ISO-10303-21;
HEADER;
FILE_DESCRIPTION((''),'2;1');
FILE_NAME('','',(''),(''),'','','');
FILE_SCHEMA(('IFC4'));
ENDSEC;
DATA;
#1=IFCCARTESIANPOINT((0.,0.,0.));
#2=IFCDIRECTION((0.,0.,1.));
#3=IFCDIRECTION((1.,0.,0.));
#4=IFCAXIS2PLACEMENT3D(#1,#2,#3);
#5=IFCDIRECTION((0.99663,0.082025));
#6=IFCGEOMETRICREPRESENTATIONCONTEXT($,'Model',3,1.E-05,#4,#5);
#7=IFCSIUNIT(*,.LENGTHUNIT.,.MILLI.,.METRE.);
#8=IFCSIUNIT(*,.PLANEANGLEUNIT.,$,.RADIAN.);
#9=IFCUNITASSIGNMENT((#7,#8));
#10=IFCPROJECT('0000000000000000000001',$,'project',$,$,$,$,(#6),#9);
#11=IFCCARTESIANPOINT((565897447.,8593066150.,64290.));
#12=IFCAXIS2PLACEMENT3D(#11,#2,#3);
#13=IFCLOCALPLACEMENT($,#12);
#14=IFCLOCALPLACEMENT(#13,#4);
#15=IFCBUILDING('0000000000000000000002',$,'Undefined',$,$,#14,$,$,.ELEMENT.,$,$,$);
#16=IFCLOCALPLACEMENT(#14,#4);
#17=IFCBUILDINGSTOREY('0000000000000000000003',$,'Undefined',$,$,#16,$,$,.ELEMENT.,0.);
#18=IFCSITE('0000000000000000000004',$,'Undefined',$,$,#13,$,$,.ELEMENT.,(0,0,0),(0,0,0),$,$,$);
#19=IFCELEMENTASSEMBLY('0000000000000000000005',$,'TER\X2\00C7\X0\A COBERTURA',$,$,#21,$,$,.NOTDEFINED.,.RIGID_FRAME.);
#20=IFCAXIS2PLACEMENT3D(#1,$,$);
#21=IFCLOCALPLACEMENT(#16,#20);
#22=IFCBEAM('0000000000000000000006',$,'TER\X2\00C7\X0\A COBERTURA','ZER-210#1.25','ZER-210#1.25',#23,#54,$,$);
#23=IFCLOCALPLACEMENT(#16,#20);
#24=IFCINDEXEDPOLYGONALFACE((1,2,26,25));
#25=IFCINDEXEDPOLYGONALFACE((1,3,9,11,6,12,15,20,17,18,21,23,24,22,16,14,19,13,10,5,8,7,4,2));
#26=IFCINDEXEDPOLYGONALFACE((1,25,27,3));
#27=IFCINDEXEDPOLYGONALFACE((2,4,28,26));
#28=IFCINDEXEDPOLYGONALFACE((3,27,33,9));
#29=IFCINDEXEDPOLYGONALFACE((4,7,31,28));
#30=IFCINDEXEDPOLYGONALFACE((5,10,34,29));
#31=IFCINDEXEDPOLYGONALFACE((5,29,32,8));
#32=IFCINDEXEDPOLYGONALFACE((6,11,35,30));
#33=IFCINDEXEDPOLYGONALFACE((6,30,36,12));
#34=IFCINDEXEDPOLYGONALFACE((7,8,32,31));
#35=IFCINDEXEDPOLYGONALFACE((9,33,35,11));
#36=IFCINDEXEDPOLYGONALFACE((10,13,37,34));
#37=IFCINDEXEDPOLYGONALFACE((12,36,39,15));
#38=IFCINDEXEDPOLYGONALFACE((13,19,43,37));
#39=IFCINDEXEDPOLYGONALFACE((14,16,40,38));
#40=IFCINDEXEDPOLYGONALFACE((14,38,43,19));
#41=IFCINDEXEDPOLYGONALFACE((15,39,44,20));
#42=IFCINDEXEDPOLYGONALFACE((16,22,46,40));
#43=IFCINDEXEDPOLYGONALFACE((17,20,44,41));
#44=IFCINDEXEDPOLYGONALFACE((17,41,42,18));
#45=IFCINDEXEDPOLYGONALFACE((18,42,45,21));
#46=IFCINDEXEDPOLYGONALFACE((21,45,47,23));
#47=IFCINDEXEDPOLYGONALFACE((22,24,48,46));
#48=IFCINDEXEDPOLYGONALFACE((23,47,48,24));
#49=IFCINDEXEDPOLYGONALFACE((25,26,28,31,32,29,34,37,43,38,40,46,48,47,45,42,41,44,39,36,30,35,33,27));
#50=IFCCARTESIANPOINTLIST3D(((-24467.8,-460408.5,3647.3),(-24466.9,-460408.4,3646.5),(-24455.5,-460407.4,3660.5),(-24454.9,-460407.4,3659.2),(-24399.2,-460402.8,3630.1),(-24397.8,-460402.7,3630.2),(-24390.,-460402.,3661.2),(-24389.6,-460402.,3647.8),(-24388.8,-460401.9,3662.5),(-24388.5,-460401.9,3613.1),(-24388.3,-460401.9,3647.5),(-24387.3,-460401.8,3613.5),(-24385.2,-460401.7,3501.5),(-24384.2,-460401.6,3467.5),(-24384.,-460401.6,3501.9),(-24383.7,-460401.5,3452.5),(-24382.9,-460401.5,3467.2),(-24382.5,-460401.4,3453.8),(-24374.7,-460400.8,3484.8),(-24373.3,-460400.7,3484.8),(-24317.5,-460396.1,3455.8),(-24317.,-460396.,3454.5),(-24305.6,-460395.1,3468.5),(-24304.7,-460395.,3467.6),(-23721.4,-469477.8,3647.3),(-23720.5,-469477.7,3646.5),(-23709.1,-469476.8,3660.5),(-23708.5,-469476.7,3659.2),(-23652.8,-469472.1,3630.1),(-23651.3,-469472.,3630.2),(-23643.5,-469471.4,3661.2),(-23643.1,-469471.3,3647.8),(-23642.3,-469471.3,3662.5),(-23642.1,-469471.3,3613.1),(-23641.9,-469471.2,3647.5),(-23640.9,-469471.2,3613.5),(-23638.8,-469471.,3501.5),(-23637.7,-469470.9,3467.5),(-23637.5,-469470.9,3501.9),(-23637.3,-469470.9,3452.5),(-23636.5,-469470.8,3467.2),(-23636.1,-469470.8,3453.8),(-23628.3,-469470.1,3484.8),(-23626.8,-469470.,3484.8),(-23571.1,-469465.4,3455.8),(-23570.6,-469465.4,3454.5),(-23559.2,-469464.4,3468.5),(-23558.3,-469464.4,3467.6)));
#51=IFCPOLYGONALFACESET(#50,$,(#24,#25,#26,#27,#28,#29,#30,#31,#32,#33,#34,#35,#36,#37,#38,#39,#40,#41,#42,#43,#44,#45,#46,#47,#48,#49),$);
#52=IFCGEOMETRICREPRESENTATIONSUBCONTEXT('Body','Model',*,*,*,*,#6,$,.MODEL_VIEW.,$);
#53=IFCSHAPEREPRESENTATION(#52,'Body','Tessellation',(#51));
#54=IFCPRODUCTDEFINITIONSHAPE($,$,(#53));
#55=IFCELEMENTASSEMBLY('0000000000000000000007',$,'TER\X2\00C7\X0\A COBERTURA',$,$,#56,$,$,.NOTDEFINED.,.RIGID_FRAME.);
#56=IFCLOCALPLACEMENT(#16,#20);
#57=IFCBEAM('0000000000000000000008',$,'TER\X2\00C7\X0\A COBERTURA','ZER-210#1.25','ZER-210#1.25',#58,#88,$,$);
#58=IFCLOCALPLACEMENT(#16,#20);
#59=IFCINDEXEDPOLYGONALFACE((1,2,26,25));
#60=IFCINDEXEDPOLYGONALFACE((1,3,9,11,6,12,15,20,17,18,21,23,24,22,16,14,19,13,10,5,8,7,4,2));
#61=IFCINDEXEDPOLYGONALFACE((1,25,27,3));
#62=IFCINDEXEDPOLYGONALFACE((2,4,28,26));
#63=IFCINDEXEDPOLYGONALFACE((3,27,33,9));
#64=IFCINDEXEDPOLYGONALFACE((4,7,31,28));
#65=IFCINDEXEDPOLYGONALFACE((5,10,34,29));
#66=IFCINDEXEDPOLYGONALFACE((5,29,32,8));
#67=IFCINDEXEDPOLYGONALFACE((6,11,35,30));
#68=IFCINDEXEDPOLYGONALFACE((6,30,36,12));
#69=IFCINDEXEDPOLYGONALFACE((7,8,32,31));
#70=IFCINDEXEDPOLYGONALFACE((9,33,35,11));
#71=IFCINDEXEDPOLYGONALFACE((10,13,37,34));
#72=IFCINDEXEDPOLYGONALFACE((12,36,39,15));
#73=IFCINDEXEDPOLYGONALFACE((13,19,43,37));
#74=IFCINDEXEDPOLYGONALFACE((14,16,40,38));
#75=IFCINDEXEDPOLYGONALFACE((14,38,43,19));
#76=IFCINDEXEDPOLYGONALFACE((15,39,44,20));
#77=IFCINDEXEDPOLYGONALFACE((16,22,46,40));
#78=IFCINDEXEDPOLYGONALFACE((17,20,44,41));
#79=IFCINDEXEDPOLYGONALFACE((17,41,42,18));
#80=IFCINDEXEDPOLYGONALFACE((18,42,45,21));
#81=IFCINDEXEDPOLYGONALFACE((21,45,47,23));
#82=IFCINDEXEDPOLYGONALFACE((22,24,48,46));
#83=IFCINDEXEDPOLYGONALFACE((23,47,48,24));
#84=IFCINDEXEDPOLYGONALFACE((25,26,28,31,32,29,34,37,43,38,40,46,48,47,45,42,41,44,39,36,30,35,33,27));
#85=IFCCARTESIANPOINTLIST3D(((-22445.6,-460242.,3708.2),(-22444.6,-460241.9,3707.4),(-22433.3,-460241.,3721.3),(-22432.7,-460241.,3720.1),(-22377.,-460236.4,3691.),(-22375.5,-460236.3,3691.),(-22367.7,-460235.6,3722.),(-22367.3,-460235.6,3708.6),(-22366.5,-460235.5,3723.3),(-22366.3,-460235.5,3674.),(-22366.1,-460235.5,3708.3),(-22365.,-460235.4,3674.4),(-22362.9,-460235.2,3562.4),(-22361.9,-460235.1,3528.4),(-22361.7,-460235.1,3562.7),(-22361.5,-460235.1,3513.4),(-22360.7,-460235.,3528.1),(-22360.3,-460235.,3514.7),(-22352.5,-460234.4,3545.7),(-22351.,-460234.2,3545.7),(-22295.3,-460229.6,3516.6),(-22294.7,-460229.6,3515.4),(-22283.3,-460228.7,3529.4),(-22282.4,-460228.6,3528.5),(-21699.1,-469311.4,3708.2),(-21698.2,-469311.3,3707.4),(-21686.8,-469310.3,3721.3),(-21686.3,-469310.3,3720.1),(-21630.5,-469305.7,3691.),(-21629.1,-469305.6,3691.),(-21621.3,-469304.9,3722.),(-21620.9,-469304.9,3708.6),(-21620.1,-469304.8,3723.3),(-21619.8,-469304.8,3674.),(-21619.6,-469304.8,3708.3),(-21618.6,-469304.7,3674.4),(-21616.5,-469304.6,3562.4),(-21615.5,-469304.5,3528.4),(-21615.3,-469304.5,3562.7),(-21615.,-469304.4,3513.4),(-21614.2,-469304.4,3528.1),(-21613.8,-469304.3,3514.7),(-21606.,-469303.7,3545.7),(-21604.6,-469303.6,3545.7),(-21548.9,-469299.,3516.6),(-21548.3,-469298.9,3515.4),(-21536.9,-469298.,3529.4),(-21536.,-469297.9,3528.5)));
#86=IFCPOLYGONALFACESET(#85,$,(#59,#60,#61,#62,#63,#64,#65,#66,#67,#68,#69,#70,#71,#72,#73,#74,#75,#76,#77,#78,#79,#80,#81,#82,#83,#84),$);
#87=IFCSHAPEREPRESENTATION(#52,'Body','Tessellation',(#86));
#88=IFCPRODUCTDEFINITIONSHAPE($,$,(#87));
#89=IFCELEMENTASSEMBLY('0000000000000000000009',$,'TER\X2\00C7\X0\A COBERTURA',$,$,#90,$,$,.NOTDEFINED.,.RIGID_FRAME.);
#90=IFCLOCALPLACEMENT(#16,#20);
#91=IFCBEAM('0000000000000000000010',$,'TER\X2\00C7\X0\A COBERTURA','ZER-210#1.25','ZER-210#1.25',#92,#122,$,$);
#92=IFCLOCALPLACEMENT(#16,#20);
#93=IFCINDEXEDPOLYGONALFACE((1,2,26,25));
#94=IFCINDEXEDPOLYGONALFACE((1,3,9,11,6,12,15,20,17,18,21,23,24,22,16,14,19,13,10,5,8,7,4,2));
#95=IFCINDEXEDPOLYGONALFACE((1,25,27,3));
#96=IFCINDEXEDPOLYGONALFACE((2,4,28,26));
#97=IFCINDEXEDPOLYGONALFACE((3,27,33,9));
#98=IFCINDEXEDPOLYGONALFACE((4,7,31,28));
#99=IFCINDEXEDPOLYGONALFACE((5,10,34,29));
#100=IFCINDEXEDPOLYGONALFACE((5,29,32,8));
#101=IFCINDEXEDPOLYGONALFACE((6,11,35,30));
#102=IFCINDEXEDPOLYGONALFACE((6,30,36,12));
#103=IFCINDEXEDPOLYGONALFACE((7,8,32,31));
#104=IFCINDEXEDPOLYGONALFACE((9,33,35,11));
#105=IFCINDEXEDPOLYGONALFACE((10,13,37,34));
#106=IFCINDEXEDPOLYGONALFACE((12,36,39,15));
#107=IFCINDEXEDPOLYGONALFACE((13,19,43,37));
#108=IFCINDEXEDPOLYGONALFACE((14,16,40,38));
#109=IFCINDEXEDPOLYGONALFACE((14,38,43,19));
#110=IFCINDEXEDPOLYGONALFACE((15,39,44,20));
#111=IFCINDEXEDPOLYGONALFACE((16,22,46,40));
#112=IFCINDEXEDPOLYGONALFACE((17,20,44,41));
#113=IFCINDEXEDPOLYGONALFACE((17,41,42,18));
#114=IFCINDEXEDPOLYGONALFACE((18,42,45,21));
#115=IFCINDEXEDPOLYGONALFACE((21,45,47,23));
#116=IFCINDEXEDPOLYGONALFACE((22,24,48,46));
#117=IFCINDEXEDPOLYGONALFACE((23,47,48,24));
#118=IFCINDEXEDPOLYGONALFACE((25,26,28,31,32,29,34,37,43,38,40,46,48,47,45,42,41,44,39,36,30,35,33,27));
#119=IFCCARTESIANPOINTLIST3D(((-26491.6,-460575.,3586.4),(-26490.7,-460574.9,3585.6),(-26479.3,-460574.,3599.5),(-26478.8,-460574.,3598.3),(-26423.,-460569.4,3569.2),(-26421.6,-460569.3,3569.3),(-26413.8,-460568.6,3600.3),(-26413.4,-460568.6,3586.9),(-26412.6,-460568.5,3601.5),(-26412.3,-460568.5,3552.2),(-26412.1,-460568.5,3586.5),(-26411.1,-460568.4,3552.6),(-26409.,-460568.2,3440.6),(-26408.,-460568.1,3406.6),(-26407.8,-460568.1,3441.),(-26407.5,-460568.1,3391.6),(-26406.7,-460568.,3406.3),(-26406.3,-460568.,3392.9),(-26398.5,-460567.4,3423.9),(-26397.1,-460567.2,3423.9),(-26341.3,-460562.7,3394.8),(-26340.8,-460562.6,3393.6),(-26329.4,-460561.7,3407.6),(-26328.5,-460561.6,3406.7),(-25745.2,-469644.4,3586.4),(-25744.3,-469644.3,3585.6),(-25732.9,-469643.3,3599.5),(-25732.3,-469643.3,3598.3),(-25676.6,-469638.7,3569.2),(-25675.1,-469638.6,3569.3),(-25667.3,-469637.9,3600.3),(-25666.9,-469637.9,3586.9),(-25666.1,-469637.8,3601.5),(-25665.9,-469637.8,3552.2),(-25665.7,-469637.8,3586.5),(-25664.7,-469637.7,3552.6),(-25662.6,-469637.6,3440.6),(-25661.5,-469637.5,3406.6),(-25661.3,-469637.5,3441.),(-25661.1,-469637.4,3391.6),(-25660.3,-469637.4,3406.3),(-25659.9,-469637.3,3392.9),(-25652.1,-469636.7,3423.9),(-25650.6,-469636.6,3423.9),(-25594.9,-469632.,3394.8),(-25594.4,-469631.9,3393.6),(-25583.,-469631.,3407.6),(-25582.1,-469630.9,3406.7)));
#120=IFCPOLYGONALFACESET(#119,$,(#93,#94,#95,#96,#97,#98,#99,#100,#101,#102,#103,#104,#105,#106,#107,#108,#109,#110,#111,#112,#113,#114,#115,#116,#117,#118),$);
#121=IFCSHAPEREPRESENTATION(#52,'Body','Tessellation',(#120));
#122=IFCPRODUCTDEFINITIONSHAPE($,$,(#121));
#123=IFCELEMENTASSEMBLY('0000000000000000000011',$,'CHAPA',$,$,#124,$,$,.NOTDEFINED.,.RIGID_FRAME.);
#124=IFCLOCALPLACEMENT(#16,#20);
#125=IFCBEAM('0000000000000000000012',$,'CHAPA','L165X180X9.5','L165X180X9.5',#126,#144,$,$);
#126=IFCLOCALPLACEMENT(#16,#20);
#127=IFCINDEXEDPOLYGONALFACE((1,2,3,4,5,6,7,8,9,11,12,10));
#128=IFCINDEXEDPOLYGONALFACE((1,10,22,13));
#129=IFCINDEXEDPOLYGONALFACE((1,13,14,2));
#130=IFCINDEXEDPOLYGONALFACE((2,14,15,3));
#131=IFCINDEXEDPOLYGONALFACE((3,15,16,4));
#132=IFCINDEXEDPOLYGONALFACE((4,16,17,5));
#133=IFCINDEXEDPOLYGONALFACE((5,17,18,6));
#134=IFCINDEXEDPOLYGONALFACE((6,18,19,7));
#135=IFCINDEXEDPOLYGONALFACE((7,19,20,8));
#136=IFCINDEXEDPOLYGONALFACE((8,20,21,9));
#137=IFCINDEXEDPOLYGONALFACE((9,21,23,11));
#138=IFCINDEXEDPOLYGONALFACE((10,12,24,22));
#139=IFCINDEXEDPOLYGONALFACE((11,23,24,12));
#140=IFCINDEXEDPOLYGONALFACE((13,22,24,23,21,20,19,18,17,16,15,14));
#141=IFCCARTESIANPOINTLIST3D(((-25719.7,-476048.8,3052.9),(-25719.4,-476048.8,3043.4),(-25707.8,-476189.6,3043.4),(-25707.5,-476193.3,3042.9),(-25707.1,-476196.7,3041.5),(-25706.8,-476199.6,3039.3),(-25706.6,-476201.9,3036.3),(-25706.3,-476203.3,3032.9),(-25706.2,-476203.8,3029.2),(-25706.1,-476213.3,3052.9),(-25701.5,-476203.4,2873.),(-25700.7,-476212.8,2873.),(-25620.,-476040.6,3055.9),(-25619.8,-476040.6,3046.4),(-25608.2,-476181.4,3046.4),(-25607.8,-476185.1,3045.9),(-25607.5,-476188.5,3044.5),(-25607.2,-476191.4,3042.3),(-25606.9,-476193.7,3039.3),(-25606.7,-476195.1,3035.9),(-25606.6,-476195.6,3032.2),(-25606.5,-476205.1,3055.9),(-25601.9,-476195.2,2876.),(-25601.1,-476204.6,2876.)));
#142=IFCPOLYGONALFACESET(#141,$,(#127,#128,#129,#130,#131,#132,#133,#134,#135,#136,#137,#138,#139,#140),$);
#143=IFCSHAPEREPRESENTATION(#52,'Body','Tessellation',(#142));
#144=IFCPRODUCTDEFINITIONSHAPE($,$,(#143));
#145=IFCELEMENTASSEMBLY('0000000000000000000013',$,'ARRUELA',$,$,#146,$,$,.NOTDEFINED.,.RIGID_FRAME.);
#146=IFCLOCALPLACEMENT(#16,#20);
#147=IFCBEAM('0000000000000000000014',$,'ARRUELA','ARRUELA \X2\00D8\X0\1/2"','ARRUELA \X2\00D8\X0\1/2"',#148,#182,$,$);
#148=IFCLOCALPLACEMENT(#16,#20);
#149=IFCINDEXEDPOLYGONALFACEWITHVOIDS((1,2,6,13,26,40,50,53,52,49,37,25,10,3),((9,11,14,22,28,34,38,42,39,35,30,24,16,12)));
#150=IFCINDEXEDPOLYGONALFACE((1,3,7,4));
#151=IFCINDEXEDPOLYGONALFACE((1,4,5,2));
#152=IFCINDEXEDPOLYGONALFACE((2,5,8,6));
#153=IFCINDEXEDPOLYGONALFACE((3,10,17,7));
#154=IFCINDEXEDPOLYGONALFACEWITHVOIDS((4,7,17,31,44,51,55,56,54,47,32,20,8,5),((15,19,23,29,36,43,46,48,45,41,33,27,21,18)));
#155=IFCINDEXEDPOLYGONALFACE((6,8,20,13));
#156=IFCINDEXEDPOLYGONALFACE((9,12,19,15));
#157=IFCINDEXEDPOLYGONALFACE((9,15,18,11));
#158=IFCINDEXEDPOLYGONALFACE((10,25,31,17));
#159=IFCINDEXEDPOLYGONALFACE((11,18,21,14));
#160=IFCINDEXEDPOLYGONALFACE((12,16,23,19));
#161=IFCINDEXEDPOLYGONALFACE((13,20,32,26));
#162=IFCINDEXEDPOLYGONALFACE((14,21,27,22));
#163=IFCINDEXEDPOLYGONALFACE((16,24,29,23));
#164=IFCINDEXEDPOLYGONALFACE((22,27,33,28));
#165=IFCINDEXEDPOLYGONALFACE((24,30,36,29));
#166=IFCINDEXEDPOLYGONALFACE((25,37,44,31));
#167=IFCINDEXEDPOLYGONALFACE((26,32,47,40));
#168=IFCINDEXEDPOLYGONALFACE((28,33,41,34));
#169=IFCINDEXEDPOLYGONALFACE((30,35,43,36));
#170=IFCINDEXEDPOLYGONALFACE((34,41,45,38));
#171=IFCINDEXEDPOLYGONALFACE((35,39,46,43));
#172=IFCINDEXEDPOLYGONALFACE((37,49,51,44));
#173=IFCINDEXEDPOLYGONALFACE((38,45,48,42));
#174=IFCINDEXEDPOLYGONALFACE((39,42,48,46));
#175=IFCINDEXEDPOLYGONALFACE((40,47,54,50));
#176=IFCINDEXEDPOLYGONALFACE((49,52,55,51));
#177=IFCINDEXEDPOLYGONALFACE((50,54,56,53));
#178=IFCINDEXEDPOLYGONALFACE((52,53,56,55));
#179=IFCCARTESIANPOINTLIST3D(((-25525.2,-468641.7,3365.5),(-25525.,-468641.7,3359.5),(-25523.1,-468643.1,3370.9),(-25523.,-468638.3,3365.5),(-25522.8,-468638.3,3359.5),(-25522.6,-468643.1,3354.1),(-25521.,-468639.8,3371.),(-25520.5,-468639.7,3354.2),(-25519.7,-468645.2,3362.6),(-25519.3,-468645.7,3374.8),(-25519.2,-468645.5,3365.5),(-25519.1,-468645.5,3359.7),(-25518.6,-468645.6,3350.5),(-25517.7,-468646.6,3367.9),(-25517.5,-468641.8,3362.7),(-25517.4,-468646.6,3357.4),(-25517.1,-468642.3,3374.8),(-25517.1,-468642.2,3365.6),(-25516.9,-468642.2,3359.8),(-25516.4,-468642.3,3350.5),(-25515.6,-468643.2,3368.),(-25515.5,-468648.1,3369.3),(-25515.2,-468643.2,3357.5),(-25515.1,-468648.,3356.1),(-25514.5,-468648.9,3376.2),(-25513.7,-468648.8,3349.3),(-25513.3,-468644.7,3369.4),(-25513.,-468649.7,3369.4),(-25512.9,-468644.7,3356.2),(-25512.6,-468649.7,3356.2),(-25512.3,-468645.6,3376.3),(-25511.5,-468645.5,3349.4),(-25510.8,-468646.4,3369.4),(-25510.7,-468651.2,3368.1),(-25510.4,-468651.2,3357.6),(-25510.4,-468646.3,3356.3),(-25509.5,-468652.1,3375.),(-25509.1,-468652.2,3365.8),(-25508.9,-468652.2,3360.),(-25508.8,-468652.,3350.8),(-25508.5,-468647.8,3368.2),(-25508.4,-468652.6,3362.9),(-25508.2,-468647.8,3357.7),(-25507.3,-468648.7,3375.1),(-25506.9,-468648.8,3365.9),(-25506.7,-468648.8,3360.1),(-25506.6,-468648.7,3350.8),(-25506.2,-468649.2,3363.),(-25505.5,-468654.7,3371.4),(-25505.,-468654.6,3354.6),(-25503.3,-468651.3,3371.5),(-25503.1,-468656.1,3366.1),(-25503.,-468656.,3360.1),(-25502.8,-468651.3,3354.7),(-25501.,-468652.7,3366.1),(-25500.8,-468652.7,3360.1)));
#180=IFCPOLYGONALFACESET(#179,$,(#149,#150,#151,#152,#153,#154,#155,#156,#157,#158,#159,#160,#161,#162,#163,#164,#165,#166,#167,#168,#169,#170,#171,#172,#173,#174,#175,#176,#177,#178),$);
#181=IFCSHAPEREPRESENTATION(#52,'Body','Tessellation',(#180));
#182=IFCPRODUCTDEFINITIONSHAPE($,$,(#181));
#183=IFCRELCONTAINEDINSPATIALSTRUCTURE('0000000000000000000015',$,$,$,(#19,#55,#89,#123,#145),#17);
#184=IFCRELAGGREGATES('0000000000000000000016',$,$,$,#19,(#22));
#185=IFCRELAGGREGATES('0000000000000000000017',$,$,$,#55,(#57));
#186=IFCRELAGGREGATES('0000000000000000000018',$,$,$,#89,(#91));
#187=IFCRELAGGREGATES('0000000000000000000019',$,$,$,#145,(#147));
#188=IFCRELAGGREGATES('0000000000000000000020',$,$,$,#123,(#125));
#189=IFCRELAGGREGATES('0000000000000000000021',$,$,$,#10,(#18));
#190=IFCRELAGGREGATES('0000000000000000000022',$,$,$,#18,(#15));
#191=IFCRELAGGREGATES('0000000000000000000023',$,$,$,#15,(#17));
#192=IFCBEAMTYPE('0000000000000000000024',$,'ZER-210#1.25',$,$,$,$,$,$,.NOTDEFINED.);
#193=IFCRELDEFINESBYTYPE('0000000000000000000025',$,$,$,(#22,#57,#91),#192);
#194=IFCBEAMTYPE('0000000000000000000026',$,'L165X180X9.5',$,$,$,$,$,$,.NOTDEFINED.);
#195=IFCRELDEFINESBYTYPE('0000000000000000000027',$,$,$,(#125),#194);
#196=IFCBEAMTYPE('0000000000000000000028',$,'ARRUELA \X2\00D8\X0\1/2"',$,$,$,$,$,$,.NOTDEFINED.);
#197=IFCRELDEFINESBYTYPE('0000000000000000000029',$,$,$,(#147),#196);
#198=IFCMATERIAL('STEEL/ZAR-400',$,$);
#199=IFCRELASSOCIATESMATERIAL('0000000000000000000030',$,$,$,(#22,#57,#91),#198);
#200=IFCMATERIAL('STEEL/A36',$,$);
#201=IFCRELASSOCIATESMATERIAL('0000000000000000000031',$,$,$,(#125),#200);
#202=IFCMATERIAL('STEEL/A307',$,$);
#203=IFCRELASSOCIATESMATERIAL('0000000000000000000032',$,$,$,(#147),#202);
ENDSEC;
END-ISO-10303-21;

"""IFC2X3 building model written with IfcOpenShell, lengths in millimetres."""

from ifc_helpers import new_model, si_unit, direction, frame, origin_with_axes, origin_2d_with_axis, place, context, subcontext, project, spatial, polyline, l_section, outline, extrude, material, type_object, element, aggregate, save


model = new_model("IFC2X3")

# Units and contexts
model_context = context("Model", 3, precision=1e-05, world=origin_with_axes(), true_north=direction((0.99663, 0.082025)))
body_context = subcontext(model_context, "Body", "Model", "MODEL_VIEW")
ifc_project = project(units=[si_unit("LENGTHUNIT", "METRE", prefix="MILLI"), si_unit("PLANEANGLEUNIT", "RADIAN")], contexts=[model_context])

# Site, building, storey
site_placement = place(None, frame((565897447.0, 8593066150.0, 64290.0), z_axis=(0.0, 0.0, 1.0), x_axis=(1.0, 0.0, 0.0)))
site = spatial("IfcSite", under=ifc_project, at=site_placement, Name="Undefined", CompositionType="ELEMENT", RefLatitude=(0, 0, 0), RefLongitude=(0, 0, 0))
building_placement = place(site_placement, origin_with_axes())
building = spatial("IfcBuilding", under=site, at=building_placement, Name="Undefined", CompositionType="ELEMENT")
storey_placement = place(building_placement, origin_with_axes())
storey = spatial("IfcBuildingStorey", under=building, at=storey_placement, Name="Undefined", CompositionType="ELEMENT", Elevation=0.0)

# Element assemblies, beams
assembly_1_placement = place(storey_placement, origin_with_axes())
assembly_1 = element("IfcElementAssembly", 1, at=assembly_1_placement, inside=storey, Name="TERÇA COBERTURA", AssemblyPlace="NOTDEFINED", PredefinedType="RIGID_FRAME")
ifc_material_1 = material(Name="STEEL/ZAR-400")
beam_type_1 = type_object("IfcBeamType", Name="ZER-210#1.25", PredefinedType="NOTDEFINED")
beam_1_placement = place(assembly_1_placement, frame((-23639.8, -469471.1, 3557.5), z_axis=(-0.029885, -0.00246, 0.99955), x_axis=(-0.082025, 0.99663, 0.0)))
beam_1 = element("IfcBeam", 2, at=beam_1_placement, type_object=beam_type_1, material=ifc_material_1, Name="TERÇA COBERTURA", Description="ZER-210#1.25", ObjectType="ZER-210#1.25", context=body_context, shape_type="SweptSolid", body=[
    extrude(outline(polyline([(-65.9, 103.7), (-78.2, 91.4), (-79.1, 92.3), (-66.4, 105.0), (0.6, 105.0), (0.6, 90.0), (-9.4, 73.0), (0.6, 56.0), (0.6, -55.7), (10.8, -73.0), (0.6, -90.3), (0.6, -103.8), (65.9, -103.7), (78.2, -91.4), (79.1, -92.3), (66.4, -105.0), (-0.6, -105.0), (-0.6, -90.0), (9.4, -73.0), (-0.6, -56.0), (-0.6, 55.7), (-10.8, 73.0), (-0.6, 90.3), (-0.6, 103.8), (-65.9, 103.7)])), frame((9100.0, 0.0, 0.0), z_axis=(-1.0, 0.0, 0.0), x_axis=(0.0, -1.0, 0.0)), (0.0, 0.0, 1.0), 9100.0),
])
aggregate(assembly_1, [beam_1])
assembly_2_placement = place(storey_placement, origin_with_axes())
assembly_2 = element("IfcElementAssembly", 3, at=assembly_2_placement, inside=storey, Name="TERÇA COBERTURA", AssemblyPlace="NOTDEFINED", PredefinedType="RIGID_FRAME")
beam_2_placement = place(assembly_2_placement, frame((-21617.6, -469304.6, 3618.4), z_axis=(-0.029885, -0.00246, 0.99955), x_axis=(-0.082025, 0.99663, 0.0)))
beam_2 = element("IfcBeam", 4, at=beam_2_placement, type_object=beam_type_1, material=ifc_material_1, Name="TERÇA COBERTURA", Description="ZER-210#1.25", ObjectType="ZER-210#1.25", context=body_context, shape_type="SweptSolid", body=[
    extrude(outline(polyline([(-65.9, 103.7), (-78.2, 91.4), (-79.1, 92.3), (-66.4, 105.0), (0.6, 105.0), (0.6, 90.0), (-9.4, 73.0), (0.6, 56.0), (0.6, -55.7), (10.8, -73.0), (0.6, -90.3), (0.6, -103.8), (65.9, -103.7), (78.2, -91.4), (79.1, -92.3), (66.4, -105.0), (-0.6, -105.0), (-0.6, -90.0), (9.4, -73.0), (-0.6, -56.0), (-0.6, 55.7), (-10.8, 73.0), (-0.6, 90.3), (-0.6, 103.8), (-65.9, 103.7)])), frame((9100.0, 0.0, 0.0), z_axis=(-1.0, 0.0, 0.0), x_axis=(0.0, -1.0, 0.0)), (0.0, 0.0, 1.0), 9100.0),
])
aggregate(assembly_2, [beam_2])
assembly_3_placement = place(storey_placement, origin_with_axes())
assembly_3 = element("IfcElementAssembly", 5, at=assembly_3_placement, inside=storey, Name="TERÇA COBERTURA", AssemblyPlace="NOTDEFINED", PredefinedType="RIGID_FRAME")
beam_3_placement = place(assembly_3_placement, frame((-25663.6, -469637.6, 3496.6), z_axis=(-0.029885, -0.00246, 0.99955), x_axis=(-0.082025, 0.99663, 0.0)))
beam_3 = element("IfcBeam", 6, at=beam_3_placement, type_object=beam_type_1, material=ifc_material_1, Name="TERÇA COBERTURA", Description="ZER-210#1.25", ObjectType="ZER-210#1.25", context=body_context, shape_type="SweptSolid", body=[
    extrude(outline(polyline([(-65.9, 103.7), (-78.2, 91.4), (-79.1, 92.3), (-66.4, 105.0), (0.6, 105.0), (0.6, 90.0), (-9.4, 73.0), (0.6, 56.0), (0.6, -55.7), (10.8, -73.0), (0.6, -90.3), (0.6, -103.8), (65.9, -103.7), (78.2, -91.4), (79.1, -92.3), (66.4, -105.0), (-0.6, -105.0), (-0.6, -90.0), (9.4, -73.0), (-0.6, -56.0), (-0.6, 55.7), (-10.8, 73.0), (-0.6, 90.3), (-0.6, 103.8), (-65.9, 103.7)])), frame((9100.0, 0.0, 0.0), z_axis=(-1.0, 0.0, 0.0), x_axis=(0.0, -1.0, 0.0)), (0.0, 0.0, 1.0), 9100.0),
])
aggregate(assembly_3, [beam_3])
assembly_4_placement = place(storey_placement, origin_with_axes())
assembly_4 = element("IfcElementAssembly", 7, at=assembly_4_placement, inside=storey, Name="CHAPA", AssemblyPlace="NOTDEFINED", PredefinedType="RIGID_FRAME")
ifc_material_2 = material(Name="STEEL/A36")
beam_type_2 = type_object("IfcBeamType", Name="L165X180X9.5", PredefinedType="NOTDEFINED")
beam_4_placement = place(assembly_4_placement, frame((-25610.6, -476122.6, 2966.0), z_axis=(-0.082025, 0.99663, 0.0), x_axis=(-0.996182, -0.081989, -0.029987)))
beam_4 = element("IfcBeam", 8, at=beam_4_placement, type_object=beam_type_2, material=ifc_material_2, Name="CHAPA", Description="L165X180X9.5", ObjectType="L165X180X9.5", context=body_context, shape_type="SweptSolid", body=[
    extrude(l_section(Depth=165.0, Width=180.0, Thickness=9.5, FilletRadius=14.2, at=origin_2d_with_axis()), frame((100.0, 0.0, 0.0), z_axis=(-1.0, 0.0, 0.0), x_axis=(0.0, -1.0, 0.0)), (0.0, 0.0, 1.0), 100.0),
])
assembly_5_placement = place(storey_placement, origin_with_axes())
assembly_5 = element("IfcElementAssembly", 9, at=assembly_5_placement, inside=storey, Name="ARRUELA", AssemblyPlace="NOTDEFINED", PredefinedType="RIGID_FRAME")
ifc_material_3 = material(Name="STEEL/A307")
beam_type_3 = type_object("IfcBeamType", Name="ARRUELA Ø1/2\"", PredefinedType="NOTDEFINED")
beam_5_placement = place(assembly_5_placement, frame((-25514.1, -468648.9, 3362.8), z_axis=(0.836984, -0.546715, 0.02368), x_axis=(0.546411, 0.837315, 0.018398)))
beam_5 = element("IfcBeam", 10, at=beam_5_placement, type_object=beam_type_3, material=ifc_material_3, Name="ARRUELA", Description="ARRUELA Ø1/2\"", ObjectType="ARRUELA Ø1/2\"", context=body_context, shape_type="SweptSolid", body=[
    extrude(outline(polyline([(-12.2, 5.9), (-8.4, 10.5), (-3.0, 13.2), (3.0, 13.2), (8.4, 10.5), (12.2, 5.9), (13.5, 0.0), (12.2, -5.9), (8.4, -10.5), (3.0, -13.2), (-3.0, -13.2), (-8.4, -10.5), (-12.2, -5.9), (-13.5, 0.0), (-12.2, 5.9)]), holes=[polyline([(5.3, 4.2), (2.9, 6.1), (0.0, 6.8), (-2.9, 6.1), (-5.3, 4.2), (-6.6, 1.5), (-6.6, -1.5), (-5.3, -4.2), (-2.9, -6.1), (0.0, -6.7), (2.9, -6.1), (5.3, -4.2), (6.6, -1.5), (6.6, 1.5), (5.3, 4.2)])]), frame((4.0, 0.0, 0.0), z_axis=(-1.0, 0.0, 0.0), x_axis=(0.0, -1.0, 0.0)), (0.0, 0.0, 1.0), 4.0),
])
aggregate(assembly_5, [beam_5])

aggregate(assembly_4, [beam_4])

save(model, "model.ifc")
